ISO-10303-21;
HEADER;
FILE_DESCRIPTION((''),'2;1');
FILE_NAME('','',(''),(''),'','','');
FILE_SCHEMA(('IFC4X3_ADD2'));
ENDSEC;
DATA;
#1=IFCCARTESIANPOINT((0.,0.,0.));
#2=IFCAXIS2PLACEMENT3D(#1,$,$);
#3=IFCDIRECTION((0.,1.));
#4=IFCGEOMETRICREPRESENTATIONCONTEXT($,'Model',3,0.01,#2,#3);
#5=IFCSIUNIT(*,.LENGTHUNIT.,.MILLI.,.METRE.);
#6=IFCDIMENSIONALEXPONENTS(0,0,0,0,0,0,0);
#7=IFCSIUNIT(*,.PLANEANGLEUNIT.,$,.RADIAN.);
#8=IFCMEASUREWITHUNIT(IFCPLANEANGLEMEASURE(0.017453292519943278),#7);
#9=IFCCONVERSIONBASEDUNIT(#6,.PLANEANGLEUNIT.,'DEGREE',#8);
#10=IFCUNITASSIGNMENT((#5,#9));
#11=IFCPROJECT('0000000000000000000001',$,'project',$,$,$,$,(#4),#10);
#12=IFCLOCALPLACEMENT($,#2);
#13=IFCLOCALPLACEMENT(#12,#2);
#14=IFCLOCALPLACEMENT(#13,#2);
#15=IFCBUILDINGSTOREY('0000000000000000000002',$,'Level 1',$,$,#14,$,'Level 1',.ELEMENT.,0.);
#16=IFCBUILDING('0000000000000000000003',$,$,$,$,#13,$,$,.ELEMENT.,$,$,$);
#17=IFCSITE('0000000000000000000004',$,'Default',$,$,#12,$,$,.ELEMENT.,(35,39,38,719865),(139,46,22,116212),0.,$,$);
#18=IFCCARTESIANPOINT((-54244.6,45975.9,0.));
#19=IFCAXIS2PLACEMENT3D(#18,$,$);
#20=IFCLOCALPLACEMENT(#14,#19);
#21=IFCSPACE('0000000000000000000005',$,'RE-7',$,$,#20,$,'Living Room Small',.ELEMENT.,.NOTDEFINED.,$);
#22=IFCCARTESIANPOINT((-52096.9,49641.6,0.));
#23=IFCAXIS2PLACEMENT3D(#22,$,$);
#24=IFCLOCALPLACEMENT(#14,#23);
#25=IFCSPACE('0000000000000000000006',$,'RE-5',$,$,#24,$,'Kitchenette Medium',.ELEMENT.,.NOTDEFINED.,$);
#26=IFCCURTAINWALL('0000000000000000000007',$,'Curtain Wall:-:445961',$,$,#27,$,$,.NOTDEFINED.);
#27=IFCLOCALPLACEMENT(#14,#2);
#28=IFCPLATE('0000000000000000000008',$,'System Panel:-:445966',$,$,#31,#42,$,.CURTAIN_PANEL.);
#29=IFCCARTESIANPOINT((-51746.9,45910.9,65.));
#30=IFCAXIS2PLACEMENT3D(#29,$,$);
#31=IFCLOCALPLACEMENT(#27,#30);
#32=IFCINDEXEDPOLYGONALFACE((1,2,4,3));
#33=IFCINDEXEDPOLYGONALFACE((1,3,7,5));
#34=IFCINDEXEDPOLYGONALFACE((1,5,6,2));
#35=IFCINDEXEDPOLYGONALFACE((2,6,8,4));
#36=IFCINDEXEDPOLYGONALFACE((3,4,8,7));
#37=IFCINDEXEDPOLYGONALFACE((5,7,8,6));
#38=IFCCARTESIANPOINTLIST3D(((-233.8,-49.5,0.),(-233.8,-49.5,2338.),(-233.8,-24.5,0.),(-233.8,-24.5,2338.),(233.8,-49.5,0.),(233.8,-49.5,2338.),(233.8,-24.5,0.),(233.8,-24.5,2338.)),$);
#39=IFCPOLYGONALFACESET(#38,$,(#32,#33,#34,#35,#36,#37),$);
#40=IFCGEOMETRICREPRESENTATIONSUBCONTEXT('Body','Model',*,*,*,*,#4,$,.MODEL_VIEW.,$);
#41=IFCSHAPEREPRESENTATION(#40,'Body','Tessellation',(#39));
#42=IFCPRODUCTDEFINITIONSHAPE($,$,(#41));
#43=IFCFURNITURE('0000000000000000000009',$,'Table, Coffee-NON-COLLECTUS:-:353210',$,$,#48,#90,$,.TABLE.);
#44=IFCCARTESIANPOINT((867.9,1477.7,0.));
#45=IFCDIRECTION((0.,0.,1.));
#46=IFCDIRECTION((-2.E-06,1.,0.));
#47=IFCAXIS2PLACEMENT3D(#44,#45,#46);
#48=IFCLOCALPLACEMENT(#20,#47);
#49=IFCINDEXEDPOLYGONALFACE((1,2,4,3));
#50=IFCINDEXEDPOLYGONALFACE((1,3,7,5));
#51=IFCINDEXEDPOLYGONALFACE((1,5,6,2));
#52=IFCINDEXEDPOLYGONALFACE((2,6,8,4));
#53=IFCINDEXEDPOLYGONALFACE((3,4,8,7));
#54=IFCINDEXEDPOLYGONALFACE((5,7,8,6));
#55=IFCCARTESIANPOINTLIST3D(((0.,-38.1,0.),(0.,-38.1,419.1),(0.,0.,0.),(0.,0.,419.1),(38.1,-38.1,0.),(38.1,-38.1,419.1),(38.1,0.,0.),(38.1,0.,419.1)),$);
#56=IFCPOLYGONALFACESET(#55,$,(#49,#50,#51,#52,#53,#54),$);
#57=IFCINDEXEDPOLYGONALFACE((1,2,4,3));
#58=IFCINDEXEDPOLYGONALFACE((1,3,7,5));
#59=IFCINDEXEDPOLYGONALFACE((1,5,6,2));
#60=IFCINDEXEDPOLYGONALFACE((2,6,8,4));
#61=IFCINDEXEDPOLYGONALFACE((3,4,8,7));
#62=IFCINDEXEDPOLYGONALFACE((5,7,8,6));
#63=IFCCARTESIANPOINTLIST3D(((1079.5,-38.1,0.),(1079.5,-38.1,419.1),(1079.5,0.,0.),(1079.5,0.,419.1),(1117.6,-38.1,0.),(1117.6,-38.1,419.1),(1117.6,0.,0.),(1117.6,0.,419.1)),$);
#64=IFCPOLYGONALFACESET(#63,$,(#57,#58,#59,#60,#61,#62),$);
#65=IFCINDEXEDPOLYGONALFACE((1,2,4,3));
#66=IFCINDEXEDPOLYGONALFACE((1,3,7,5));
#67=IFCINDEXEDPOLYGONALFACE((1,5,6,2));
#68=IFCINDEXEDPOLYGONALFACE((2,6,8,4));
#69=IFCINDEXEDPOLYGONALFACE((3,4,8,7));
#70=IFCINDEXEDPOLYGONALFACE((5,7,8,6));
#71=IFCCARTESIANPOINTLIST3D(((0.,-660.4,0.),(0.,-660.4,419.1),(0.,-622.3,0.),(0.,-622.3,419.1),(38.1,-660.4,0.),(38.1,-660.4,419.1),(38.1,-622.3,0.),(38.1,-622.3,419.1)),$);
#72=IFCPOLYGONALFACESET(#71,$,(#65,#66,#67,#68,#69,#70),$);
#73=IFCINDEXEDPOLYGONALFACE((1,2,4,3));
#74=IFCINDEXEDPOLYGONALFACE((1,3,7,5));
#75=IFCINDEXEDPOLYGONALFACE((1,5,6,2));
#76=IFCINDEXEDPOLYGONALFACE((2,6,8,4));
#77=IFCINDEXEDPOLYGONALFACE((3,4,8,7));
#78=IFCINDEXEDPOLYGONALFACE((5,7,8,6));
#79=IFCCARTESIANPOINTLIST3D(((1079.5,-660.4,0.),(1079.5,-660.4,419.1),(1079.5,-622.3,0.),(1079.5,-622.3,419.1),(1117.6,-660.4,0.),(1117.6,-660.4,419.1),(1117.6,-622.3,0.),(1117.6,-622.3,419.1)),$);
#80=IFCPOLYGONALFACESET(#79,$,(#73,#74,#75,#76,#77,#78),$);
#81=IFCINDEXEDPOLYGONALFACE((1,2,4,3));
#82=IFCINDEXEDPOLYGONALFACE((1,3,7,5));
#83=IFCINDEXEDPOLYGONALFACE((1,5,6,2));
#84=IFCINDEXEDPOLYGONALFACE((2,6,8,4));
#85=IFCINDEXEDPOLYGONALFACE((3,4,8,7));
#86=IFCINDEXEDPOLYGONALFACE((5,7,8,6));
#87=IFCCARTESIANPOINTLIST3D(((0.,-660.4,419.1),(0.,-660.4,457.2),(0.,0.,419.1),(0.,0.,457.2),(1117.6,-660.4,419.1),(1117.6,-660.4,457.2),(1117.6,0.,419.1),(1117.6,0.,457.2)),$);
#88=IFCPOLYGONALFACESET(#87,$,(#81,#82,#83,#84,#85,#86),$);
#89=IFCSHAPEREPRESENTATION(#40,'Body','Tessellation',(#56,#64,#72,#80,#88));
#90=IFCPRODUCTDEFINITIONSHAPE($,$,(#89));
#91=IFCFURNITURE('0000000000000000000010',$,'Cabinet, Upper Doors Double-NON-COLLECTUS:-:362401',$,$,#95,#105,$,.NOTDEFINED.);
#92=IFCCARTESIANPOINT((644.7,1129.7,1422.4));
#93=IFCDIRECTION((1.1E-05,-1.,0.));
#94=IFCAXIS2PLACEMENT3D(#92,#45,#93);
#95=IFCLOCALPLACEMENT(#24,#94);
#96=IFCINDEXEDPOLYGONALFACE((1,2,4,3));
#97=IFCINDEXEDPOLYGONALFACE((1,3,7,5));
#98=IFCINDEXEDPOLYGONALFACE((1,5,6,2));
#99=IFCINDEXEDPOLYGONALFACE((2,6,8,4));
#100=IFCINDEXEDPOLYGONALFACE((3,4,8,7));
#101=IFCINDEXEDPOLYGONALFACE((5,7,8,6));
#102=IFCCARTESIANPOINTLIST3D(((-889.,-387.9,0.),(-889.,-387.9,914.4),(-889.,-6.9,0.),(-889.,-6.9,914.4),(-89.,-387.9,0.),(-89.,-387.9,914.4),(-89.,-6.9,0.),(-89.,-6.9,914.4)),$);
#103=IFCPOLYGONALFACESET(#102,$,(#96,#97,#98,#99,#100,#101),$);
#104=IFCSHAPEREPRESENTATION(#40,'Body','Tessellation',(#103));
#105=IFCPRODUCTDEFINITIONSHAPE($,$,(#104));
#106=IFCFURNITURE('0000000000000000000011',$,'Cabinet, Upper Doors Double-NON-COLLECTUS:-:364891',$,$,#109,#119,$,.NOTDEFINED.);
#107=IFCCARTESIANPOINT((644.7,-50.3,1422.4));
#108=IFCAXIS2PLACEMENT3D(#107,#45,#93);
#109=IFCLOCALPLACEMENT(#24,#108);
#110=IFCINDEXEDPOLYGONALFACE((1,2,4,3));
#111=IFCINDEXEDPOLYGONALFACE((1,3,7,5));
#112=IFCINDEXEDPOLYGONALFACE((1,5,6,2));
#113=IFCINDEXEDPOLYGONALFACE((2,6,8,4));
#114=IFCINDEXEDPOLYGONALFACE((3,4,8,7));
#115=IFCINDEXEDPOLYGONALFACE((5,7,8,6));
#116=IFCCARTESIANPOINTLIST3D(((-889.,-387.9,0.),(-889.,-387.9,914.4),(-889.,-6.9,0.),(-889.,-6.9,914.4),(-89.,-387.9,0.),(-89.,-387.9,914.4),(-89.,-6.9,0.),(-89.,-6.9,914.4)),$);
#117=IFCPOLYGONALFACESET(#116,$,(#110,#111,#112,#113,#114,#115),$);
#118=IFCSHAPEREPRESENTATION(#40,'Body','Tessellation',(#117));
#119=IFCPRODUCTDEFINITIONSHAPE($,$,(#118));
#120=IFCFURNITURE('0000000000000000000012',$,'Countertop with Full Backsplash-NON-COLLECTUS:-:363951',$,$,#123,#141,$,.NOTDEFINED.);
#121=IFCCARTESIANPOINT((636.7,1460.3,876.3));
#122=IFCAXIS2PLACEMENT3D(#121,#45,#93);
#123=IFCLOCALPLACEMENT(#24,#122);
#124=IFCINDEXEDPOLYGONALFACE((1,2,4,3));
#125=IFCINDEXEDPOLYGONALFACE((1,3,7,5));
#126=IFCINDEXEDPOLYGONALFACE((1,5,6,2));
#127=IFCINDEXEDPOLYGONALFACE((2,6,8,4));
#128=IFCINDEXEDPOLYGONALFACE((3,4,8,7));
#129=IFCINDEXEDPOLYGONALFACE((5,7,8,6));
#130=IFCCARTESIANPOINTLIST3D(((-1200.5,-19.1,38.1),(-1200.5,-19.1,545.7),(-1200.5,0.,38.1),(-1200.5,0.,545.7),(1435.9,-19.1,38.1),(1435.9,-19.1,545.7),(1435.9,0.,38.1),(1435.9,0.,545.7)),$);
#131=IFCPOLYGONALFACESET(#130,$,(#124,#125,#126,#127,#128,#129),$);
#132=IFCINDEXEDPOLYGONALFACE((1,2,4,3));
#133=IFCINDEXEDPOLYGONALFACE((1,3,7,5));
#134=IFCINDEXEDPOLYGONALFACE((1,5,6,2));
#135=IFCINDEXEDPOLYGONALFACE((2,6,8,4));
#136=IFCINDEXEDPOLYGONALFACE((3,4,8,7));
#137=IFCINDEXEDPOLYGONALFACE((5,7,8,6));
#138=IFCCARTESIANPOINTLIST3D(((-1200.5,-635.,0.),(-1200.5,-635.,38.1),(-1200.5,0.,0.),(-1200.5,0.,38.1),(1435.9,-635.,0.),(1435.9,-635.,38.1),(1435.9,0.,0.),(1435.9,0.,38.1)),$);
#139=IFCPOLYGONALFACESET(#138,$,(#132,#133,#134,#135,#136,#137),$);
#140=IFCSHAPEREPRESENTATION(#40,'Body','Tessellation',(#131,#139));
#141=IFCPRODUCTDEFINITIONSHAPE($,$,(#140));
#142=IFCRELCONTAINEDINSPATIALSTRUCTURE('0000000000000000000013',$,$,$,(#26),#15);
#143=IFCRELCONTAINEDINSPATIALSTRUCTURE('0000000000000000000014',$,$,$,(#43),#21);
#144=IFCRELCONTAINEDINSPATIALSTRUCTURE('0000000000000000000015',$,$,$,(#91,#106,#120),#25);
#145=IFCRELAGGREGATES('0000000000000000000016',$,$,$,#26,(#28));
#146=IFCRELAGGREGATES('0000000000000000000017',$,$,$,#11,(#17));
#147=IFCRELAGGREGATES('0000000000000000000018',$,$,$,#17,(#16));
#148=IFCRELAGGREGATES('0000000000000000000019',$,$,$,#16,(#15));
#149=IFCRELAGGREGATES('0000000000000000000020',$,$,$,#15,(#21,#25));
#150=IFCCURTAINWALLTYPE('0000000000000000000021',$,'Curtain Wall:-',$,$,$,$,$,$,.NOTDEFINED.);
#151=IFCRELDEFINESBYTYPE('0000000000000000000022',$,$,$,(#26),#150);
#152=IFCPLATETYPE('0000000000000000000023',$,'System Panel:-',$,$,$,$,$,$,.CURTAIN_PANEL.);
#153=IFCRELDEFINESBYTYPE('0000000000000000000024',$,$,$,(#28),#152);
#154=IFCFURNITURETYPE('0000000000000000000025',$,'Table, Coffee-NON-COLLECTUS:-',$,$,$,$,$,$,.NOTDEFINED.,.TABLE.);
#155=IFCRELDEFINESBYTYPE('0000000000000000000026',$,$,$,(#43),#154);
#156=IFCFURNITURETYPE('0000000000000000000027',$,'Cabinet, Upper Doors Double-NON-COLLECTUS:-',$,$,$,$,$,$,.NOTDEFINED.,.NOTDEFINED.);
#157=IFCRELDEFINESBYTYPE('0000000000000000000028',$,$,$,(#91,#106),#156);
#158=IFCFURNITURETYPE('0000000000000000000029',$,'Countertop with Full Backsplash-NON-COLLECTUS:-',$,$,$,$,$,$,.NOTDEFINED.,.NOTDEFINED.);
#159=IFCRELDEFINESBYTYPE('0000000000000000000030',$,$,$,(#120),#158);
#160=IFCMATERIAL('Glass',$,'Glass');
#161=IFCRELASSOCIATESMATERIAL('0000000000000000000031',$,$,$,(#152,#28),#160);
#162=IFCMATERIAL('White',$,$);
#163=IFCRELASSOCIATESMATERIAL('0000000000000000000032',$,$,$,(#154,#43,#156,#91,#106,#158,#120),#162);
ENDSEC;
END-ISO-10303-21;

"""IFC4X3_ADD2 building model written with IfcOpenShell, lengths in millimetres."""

from ifc_helpers import new_model, entity, si_unit, converted_unit, direction, frame, frame_2d, origin, origin_2d_with_axis, place, context, subcontext, project, spatial, rectangle, extrude, source, transform, mapped, material, type_object, type_shapes, element, aggregate, save


model = new_model("IFC4X3_ADD2")

# Units and contexts
model_context = context("Model", 3, precision=0.01, world=origin(), true_north=direction((0.0, 1.0)))
body_context = subcontext(model_context, "Body", "Model", "MODEL_VIEW")
ifc_project = project(units=[si_unit("LENGTHUNIT", "METRE", prefix="MILLI"), converted_unit("PLANEANGLEUNIT", "DEGREE", entity("IfcPlaneAngleMeasure", 0.017453292519943278), si_unit("PLANEANGLEUNIT", "RADIAN"), dimensions=[0, 0, 0, 0, 0, 0, 0])], contexts=[model_context])

# Site, building, storey
site_placement = place(None, origin())
site = spatial("IfcSite", under=ifc_project, at=site_placement, Name="Default", CompositionType="ELEMENT", RefLatitude=(35, 39, 38, 719865), RefLongitude=(139, 46, 22, 116212), RefElevation=0.0)
building_placement = place(site_placement, origin())
building = spatial("IfcBuilding", under=site, at=building_placement, CompositionType="ELEMENT")
storey_placement = place(building_placement, origin())
storey = spatial("IfcBuildingStorey", under=building, at=storey_placement, Name="Level 1", LongName="Level 1", CompositionType="ELEMENT", Elevation=0.0)

# Curtain wall
curtain_wall_type = type_object("IfcCurtainWallType", Name="Curtain Wall:-", PredefinedType="NOTDEFINED")
curtain_wall_placement = place(storey_placement, origin())
curtain_wall = element("IfcCurtainWall", 1, at=curtain_wall_placement, inside=storey, type_object=curtain_wall_type, Name="Curtain Wall:-:445961", PredefinedType="NOTDEFINED")

# Plate
ifc_material_1 = material(Name="Glass", Category="Glass")
plate_type = type_object("IfcPlateType", Name="System Panel:-", PredefinedType="CURTAIN_PANEL", material=ifc_material_1)
shared_shape_1 = source(origin(), body_context, "Body", "SweptSolid", [
    extrude(rectangle(XDim=25.0, YDim=467.6, at=frame_2d((0.0, 0.0), x_axis=(1.0, 0.0))), frame((0.0, -37.0, 0.0), z_axis=(0.0, 0.0, 1.0), x_axis=(0.0, 1.0, 0.0)), (0.0, 0.0, 1.0), 2338.0),
])
type_shapes(plate_type, [shared_shape_1])
plate_placement = place(curtain_wall_placement, frame((-51746.9, 45910.9, 65.0)))
plate = element("IfcPlate", 2, at=plate_placement, type_object=plate_type, material=ifc_material_1, Name="System Panel:-:445966", PredefinedType="CURTAIN_PANEL", context=body_context, shape_type="MappedRepresentation", body=[
    mapped(shared_shape_1, transform((0.0, 0.0, 0.0), scale=1.0)),
])

aggregate(curtain_wall, [plate])

# Shared definitions
space_1_placement = place(storey_placement, frame((-54244.6, 45975.9, 0.0)))
space_1 = spatial("IfcSpace", under=storey, at=space_1_placement, Name="RE-7", LongName="Living Room Small", CompositionType="ELEMENT", PredefinedType="NOTDEFINED")

# Furniture
ifc_material_2 = material(Name="White")
furniture_type_1 = type_object("IfcFurnitureType", Name="Table, Coffee-NON-COLLECTUS:-", AssemblyPlace="NOTDEFINED", PredefinedType="TABLE", material=ifc_material_2)
shared_shape_2 = source(origin(), body_context, "Body", "SweptSolid", [
    extrude(rectangle(XDim=38.1, YDim=38.1, at=origin_2d_with_axis()), frame((19.1, -19.1, 0.0), z_axis=(0.0, 0.0, 1.0), x_axis=(0.0, -1.0, 0.0)), (0.0, 0.0, 1.0), 419.1),
    extrude(rectangle(XDim=38.1, YDim=38.1, at=origin_2d_with_axis()), frame((1098.6, -19.1, 0.0), z_axis=(0.0, 0.0, 1.0), x_axis=(0.0, 1.0, 0.0)), (0.0, 0.0, 1.0), 419.1),
    extrude(rectangle(XDim=38.1, YDim=38.1, at=origin_2d_with_axis()), frame((19.1, -641.3, 0.0), z_axis=(0.0, 0.0, 1.0), x_axis=(0.0, -1.0, 0.0)), (0.0, 0.0, 1.0), 419.1),
    extrude(rectangle(XDim=38.1, YDim=38.1, at=origin_2d_with_axis()), frame((1098.6, -641.3, 0.0), z_axis=(0.0, 0.0, 1.0), x_axis=(0.0, 1.0, 0.0)), (0.0, 0.0, 1.0), 419.1),
    extrude(rectangle(XDim=660.4, YDim=1117.6, at=origin_2d_with_axis()), frame((558.8, -330.2, 419.1), z_axis=(0.0, 0.0, 1.0), x_axis=(0.0, 1.0, 0.0)), (0.0, 0.0, 1.0), 38.1),
])
type_shapes(furniture_type_1, [shared_shape_2])
furniture_1_placement = place(space_1_placement, frame((867.9, 1477.7, 0.0), z_axis=(0.0, 0.0, 1.0), x_axis=(-0.000002, 1.0, 0.0)))
element("IfcFurniture", 3, at=furniture_1_placement, inside=space_1, type_object=furniture_type_1, material=ifc_material_2, Name="Table, Coffee-NON-COLLECTUS:-:353210", PredefinedType="TABLE", context=body_context, shape_type="MappedRepresentation", body=[
    mapped(shared_shape_2, transform((0.0, 0.0, 0.0), scale=1.0)),
])

# Shared definitions
space_2_placement = place(storey_placement, frame((-52096.9, 49641.6, 0.0)))
space_2 = spatial("IfcSpace", under=storey, at=space_2_placement, Name="RE-5", LongName="Kitchenette Medium", CompositionType="ELEMENT", PredefinedType="NOTDEFINED")

# Furniture
furniture_type_2 = type_object("IfcFurnitureType", Name="Cabinet, Upper Doors Double-NON-COLLECTUS:-", AssemblyPlace="NOTDEFINED", PredefinedType="NOTDEFINED", material=ifc_material_2)
shared_shape_3 = source(origin(), body_context, "Body", "SweptSolid", [
    extrude(rectangle(XDim=800.0, YDim=381.0, at=frame_2d((0.0, 0.0), x_axis=(1.0, 0.0))), frame((-489.0, -197.4, 0.0), z_axis=(0.0, 0.0, 1.0), x_axis=(-1.0, 0.0, 0.0)), (0.0, 0.0, 1.0), 914.4),
])
type_shapes(furniture_type_2, [shared_shape_3])
for number, where, z_axis, x_axis, name in (
    (4, (644.7, 1129.7, 1422.4), (0.0, 0.0, 1.0), (0.000011, -1.0, 0.0), "Cabinet, Upper Doors Double-NON-COLLECTUS:-:362401"),
    (5, (644.7, -50.3, 1422.4), (0.0, 0.0, 1.0), (0.000011, -1.0, 0.0), "Cabinet, Upper Doors Double-NON-COLLECTUS:-:364891"),
):
    element("IfcFurniture", number, at=place(space_2_placement, frame(where, z_axis=z_axis, x_axis=x_axis)), inside=space_2, type_object=furniture_type_2, material=ifc_material_2, Name=name, PredefinedType="NOTDEFINED", context=body_context, shape_type="MappedRepresentation", body=[
        mapped(shared_shape_3, transform((0.0, 0.0, 0.0), scale=1.0)),
    ])
furniture_type_3 = type_object("IfcFurnitureType", Name="Countertop with Full Backsplash-NON-COLLECTUS:-", AssemblyPlace="NOTDEFINED", PredefinedType="NOTDEFINED", material=ifc_material_2)
shared_shape_4 = source(origin(), body_context, "Body", "SweptSolid", [
    extrude(rectangle(XDim=19.1, YDim=2636.4, at=frame_2d((0.0, 0.0), x_axis=(1.0, 0.0))), frame((117.7, -9.5, 38.1), z_axis=(0.0, 0.0, 1.0), x_axis=(0.0, -1.0, 0.0)), (0.0, 0.0, 1.0), 507.6),
    extrude(rectangle(XDim=2636.4, YDim=635.0, at=origin_2d_with_axis()), frame((117.7, -317.5, 0.0), z_axis=(0.0, 0.0, 1.0), x_axis=(-1.0, 0.0, 0.0)), (0.0, 0.0, 1.0), 38.1),
])
type_shapes(furniture_type_3, [shared_shape_4])
furniture_2_placement = place(space_2_placement, frame((636.7, 1460.3, 876.3), z_axis=(0.0, 0.0, 1.0), x_axis=(0.000011, -1.0, 0.0)))
element("IfcFurniture", 6, at=furniture_2_placement, inside=space_2, type_object=furniture_type_3, material=ifc_material_2, Name="Countertop with Full Backsplash-NON-COLLECTUS:-:363951", PredefinedType="NOTDEFINED", context=body_context, shape_type="MappedRepresentation", body=[
    mapped(shared_shape_4, transform((0.0, 0.0, 0.0), scale=1.0)),
])

save(model, "model.ifc")
